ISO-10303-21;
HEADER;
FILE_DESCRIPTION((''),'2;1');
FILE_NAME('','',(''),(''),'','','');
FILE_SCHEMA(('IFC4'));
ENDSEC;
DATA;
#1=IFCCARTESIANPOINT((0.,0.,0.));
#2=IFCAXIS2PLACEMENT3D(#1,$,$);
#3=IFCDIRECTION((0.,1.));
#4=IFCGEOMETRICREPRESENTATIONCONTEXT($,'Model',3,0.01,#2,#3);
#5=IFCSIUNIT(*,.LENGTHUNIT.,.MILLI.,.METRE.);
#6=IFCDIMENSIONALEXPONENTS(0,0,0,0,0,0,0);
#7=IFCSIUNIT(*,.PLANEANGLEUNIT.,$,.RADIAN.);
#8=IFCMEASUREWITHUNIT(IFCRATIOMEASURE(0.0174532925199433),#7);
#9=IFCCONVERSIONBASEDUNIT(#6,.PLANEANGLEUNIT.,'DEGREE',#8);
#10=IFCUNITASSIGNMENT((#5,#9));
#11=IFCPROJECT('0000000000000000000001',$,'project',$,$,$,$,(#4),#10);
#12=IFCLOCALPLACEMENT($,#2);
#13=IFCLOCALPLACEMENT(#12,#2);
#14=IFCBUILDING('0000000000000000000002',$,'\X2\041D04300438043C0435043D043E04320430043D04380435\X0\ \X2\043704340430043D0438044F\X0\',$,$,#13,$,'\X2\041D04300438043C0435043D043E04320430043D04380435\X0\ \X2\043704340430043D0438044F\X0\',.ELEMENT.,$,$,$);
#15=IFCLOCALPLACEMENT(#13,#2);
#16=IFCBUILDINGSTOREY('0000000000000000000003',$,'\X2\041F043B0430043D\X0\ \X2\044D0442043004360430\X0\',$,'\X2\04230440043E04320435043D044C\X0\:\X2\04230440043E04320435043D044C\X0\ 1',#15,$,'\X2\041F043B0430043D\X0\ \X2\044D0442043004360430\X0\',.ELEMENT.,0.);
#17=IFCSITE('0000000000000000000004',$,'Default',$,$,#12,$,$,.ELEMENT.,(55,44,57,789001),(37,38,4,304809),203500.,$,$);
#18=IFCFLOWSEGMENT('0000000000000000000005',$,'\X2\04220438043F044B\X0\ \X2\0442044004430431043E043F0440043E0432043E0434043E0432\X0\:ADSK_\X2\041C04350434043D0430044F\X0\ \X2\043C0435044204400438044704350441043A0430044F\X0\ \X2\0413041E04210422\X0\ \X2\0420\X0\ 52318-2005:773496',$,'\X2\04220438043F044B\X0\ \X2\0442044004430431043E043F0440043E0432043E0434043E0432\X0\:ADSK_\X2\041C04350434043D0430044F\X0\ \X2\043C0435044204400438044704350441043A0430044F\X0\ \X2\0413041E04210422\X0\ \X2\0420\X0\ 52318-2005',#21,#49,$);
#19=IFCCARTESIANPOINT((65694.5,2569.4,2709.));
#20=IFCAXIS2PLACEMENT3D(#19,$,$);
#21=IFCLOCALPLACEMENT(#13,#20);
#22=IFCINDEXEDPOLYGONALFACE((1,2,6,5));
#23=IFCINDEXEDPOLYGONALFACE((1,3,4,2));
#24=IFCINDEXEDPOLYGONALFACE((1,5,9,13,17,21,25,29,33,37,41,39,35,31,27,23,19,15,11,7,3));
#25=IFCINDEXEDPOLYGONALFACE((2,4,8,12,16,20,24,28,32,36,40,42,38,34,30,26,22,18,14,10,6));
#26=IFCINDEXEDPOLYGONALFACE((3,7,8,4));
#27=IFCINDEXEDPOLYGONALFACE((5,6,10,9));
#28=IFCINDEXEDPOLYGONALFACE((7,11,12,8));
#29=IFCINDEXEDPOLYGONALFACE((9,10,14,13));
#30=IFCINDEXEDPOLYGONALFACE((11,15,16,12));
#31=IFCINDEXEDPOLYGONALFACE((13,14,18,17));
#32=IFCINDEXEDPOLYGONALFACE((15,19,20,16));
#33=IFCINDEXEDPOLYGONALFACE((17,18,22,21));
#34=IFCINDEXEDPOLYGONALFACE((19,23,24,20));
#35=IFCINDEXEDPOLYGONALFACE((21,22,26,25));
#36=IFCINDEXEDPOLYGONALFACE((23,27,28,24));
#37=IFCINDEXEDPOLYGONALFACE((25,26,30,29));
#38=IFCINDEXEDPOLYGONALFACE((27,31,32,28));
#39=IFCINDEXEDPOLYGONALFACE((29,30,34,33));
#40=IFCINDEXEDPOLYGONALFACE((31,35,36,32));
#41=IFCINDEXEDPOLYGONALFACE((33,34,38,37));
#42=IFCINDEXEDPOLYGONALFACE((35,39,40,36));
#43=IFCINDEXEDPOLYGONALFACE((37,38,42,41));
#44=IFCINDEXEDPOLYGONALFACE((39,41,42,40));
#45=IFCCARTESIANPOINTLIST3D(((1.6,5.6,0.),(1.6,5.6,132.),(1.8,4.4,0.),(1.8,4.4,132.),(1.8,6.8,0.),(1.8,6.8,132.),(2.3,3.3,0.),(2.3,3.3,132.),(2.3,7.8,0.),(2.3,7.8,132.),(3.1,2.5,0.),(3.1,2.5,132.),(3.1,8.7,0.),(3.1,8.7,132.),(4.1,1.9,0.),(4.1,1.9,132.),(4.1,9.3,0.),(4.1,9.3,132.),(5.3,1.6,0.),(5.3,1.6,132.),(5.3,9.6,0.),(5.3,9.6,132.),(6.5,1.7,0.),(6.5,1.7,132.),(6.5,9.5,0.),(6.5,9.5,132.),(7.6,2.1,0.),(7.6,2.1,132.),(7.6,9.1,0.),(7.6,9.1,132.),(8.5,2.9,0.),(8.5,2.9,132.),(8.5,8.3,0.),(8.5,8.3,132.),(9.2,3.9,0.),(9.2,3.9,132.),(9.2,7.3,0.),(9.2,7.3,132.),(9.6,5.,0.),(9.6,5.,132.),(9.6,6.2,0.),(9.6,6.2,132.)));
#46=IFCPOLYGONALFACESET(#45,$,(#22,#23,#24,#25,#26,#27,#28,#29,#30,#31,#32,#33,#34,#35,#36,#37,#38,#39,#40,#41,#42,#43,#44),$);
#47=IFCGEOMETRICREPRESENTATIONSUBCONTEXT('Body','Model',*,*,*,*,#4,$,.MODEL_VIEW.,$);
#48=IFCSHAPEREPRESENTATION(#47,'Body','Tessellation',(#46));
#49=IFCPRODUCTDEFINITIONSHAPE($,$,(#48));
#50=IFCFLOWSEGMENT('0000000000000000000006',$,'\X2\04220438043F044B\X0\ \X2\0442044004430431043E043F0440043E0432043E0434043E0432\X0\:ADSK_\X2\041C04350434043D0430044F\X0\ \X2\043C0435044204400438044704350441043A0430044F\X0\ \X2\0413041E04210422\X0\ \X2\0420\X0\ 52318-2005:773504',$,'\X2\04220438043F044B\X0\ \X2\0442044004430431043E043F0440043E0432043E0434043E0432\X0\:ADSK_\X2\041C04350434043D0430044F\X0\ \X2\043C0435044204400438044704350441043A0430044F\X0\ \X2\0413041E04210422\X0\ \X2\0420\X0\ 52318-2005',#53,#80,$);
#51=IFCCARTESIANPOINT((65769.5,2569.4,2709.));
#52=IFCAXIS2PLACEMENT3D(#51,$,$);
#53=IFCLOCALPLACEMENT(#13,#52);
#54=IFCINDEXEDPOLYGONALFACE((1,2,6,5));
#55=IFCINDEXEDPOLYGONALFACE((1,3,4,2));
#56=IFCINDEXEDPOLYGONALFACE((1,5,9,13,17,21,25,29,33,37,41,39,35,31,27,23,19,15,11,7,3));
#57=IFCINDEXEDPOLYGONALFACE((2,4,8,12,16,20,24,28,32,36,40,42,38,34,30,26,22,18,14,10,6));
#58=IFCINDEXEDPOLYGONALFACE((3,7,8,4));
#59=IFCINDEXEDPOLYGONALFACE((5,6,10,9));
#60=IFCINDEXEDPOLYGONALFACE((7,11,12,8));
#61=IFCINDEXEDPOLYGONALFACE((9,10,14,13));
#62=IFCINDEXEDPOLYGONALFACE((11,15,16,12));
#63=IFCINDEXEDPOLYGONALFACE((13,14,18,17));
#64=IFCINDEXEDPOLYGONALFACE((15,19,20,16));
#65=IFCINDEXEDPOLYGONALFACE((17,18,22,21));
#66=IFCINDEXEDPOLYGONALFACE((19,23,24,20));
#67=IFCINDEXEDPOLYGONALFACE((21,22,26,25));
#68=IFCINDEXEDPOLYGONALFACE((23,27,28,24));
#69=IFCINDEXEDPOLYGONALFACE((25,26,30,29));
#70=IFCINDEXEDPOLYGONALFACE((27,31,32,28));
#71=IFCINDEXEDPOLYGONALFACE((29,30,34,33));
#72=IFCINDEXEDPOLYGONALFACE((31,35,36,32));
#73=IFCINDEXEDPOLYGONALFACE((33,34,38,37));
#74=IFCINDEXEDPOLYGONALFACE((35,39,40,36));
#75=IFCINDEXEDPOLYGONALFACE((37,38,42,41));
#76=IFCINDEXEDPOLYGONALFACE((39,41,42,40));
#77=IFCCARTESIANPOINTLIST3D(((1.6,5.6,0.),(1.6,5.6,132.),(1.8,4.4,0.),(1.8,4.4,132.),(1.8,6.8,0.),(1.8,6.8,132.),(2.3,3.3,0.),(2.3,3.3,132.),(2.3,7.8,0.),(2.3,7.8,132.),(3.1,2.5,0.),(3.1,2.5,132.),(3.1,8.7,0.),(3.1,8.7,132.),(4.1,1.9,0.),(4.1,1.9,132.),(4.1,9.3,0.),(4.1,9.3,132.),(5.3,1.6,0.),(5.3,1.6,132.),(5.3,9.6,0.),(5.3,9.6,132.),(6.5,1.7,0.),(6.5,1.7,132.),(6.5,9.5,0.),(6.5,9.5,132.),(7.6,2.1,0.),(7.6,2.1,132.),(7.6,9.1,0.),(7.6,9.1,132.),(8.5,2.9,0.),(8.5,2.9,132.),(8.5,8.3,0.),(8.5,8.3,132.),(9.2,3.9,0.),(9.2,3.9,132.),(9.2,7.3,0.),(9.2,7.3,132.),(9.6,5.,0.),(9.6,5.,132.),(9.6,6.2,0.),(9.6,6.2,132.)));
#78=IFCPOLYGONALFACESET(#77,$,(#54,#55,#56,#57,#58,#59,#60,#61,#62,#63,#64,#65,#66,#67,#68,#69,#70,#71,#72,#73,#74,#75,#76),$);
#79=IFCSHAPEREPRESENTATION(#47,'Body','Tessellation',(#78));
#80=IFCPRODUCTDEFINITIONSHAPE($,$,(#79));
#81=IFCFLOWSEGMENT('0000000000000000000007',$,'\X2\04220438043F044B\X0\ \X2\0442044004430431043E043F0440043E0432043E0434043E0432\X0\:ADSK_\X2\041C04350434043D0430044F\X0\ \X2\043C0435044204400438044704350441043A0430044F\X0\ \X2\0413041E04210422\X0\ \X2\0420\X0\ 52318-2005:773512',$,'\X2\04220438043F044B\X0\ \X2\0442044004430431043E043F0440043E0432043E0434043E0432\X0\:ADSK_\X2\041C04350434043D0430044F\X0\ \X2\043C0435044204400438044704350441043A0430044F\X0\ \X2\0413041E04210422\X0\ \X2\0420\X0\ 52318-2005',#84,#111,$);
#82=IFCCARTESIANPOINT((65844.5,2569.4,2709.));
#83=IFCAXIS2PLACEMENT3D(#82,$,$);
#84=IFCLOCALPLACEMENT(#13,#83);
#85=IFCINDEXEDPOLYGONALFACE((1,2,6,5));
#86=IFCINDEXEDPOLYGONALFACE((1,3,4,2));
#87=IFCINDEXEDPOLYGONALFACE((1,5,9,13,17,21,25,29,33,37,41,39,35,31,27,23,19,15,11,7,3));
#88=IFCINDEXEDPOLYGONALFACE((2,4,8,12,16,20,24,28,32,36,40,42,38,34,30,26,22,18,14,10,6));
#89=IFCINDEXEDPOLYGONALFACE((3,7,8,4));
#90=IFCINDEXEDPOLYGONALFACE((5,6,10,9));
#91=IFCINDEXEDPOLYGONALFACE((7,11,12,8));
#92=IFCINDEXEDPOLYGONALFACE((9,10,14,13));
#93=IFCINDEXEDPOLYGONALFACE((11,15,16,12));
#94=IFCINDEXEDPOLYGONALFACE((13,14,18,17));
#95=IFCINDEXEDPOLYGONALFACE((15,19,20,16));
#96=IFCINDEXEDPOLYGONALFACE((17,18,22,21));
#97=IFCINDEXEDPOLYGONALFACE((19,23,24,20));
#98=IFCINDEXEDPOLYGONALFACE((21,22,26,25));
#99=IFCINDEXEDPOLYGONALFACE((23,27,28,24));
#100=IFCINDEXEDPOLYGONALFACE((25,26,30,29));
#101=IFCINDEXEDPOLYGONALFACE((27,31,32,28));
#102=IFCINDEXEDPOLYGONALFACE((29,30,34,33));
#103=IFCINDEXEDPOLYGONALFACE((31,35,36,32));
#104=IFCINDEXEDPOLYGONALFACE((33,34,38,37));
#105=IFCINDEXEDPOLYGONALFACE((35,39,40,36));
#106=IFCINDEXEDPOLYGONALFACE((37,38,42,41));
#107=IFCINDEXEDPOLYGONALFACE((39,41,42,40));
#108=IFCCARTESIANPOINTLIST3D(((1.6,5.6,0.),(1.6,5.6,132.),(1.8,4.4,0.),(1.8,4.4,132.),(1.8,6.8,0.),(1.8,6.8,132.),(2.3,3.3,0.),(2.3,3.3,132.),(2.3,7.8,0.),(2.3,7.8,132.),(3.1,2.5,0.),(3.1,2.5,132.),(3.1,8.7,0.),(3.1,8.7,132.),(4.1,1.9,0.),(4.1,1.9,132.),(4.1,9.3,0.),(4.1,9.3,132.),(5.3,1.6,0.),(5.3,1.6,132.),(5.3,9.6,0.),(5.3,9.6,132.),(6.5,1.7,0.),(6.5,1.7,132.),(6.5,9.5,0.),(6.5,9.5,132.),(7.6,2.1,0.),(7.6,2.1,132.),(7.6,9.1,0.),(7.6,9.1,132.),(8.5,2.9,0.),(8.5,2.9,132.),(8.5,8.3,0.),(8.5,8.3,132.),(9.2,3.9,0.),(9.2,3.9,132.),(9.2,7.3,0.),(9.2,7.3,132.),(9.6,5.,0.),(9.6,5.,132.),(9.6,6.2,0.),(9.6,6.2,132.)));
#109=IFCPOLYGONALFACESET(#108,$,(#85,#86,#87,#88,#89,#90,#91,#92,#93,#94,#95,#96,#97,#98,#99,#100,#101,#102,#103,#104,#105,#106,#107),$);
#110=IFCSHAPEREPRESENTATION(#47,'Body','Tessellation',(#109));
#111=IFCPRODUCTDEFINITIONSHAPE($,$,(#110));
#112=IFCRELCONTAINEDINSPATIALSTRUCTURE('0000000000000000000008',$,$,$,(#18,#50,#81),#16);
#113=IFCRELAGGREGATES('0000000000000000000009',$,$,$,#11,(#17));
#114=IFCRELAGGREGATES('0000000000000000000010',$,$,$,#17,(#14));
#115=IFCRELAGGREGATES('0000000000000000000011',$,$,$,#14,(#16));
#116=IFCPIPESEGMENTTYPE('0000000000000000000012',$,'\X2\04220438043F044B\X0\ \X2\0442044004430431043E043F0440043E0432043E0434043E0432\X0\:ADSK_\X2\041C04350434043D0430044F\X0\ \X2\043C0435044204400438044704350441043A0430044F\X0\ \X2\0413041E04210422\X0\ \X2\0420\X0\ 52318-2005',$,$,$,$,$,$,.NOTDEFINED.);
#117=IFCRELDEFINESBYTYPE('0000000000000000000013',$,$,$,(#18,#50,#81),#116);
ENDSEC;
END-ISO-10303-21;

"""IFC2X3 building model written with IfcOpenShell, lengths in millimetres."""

from ifc_helpers import new_model, entity, si_unit, converted_unit, direction, frame, origin, origin_2d_with_axis, place, context, subcontext, project, spatial, circle, extrude, type_object, element, save


model = new_model("IFC2X3")

# Units and contexts
model_context = context("Model", 3, precision=0.01, world=origin(), true_north=direction((0.0, 1.0)))
body_context = subcontext(model_context, "Body", "Model", "MODEL_VIEW")
ifc_project = project(units=[si_unit("LENGTHUNIT", "METRE", prefix="MILLI"), converted_unit("PLANEANGLEUNIT", "DEGREE", entity("IfcRatioMeasure", 0.0174532925199433), si_unit("PLANEANGLEUNIT", "RADIAN"), dimensions=[0, 0, 0, 0, 0, 0, 0])], contexts=[model_context])

# Site, building, storey
site_placement = place(None, frame((0.0, 0.0, 0.0)))
site = spatial("IfcSite", under=ifc_project, at=site_placement, Name="Default", CompositionType="ELEMENT", RefLatitude=(55, 44, 57, 789001), RefLongitude=(37, 38, 4, 304809), RefElevation=203500.0)
building_placement = place(site_placement, origin())
building = spatial("IfcBuilding", under=site, at=building_placement, Name="Наименование здания", LongName="Наименование здания", CompositionType="ELEMENT")
storey_placement = place(building_placement, origin())
storey = spatial("IfcBuildingStorey", under=building, at=storey_placement, Name="План этажа", ObjectType="Уровень:Уровень 1", LongName="План этажа", CompositionType="ELEMENT", Elevation=0.0)

# Flow segments
pipe_segment_type = type_object("IfcPipeSegmentType", Name="Типы трубопроводов:ADSK_Медная метрическая ГОСТ Р 52318-2005", PredefinedType="NOTDEFINED")
for number, where, name in (
    (1, (65694.5, 2569.4, 2709.0), "Типы трубопроводов:ADSK_Медная метрическая ГОСТ Р 52318-2005:773496"),
    (2, (65769.5, 2569.4, 2709.0), "Типы трубопроводов:ADSK_Медная метрическая ГОСТ Р 52318-2005:773504"),
):
    element("IfcFlowSegment", number, at=place(building_placement, frame(where)), inside=storey, type_object=pipe_segment_type, Name=name, ObjectType="Типы трубопроводов:ADSK_Медная метрическая ГОСТ Р 52318-2005", context=body_context, shape_type="SweptSolid", body=[
        extrude(circle(Radius=4.0, at=origin_2d_with_axis()), frame((5.6, 5.6, 0.0), z_axis=(0.0, 0.0, 1.0), x_axis=(-1.0, 0.0, 0.0)), (0.0, 0.0, 1.0), 132.0),
    ])
flow_segment_1_placement = place(building_placement, frame((65844.5, 2569.4, 2709.0)))
element("IfcFlowSegment", 3, at=flow_segment_1_placement, inside=storey, type_object=pipe_segment_type, Name="Типы трубопроводов:ADSK_Медная метрическая ГОСТ Р 52318-2005:773512", ObjectType="Типы трубопроводов:ADSK_Медная метрическая ГОСТ Р 52318-2005", context=body_context, shape_type="SweptSolid", body=[
    extrude(circle(Radius=4.0, at=origin_2d_with_axis()), frame((5.6, 5.6, 0.0), z_axis=(0.0, 0.0, 1.0), x_axis=(-1.0, 0.0, 0.0)), (0.0, 0.0, 1.0), 132.0),
])

save(model, "model.ifc")
